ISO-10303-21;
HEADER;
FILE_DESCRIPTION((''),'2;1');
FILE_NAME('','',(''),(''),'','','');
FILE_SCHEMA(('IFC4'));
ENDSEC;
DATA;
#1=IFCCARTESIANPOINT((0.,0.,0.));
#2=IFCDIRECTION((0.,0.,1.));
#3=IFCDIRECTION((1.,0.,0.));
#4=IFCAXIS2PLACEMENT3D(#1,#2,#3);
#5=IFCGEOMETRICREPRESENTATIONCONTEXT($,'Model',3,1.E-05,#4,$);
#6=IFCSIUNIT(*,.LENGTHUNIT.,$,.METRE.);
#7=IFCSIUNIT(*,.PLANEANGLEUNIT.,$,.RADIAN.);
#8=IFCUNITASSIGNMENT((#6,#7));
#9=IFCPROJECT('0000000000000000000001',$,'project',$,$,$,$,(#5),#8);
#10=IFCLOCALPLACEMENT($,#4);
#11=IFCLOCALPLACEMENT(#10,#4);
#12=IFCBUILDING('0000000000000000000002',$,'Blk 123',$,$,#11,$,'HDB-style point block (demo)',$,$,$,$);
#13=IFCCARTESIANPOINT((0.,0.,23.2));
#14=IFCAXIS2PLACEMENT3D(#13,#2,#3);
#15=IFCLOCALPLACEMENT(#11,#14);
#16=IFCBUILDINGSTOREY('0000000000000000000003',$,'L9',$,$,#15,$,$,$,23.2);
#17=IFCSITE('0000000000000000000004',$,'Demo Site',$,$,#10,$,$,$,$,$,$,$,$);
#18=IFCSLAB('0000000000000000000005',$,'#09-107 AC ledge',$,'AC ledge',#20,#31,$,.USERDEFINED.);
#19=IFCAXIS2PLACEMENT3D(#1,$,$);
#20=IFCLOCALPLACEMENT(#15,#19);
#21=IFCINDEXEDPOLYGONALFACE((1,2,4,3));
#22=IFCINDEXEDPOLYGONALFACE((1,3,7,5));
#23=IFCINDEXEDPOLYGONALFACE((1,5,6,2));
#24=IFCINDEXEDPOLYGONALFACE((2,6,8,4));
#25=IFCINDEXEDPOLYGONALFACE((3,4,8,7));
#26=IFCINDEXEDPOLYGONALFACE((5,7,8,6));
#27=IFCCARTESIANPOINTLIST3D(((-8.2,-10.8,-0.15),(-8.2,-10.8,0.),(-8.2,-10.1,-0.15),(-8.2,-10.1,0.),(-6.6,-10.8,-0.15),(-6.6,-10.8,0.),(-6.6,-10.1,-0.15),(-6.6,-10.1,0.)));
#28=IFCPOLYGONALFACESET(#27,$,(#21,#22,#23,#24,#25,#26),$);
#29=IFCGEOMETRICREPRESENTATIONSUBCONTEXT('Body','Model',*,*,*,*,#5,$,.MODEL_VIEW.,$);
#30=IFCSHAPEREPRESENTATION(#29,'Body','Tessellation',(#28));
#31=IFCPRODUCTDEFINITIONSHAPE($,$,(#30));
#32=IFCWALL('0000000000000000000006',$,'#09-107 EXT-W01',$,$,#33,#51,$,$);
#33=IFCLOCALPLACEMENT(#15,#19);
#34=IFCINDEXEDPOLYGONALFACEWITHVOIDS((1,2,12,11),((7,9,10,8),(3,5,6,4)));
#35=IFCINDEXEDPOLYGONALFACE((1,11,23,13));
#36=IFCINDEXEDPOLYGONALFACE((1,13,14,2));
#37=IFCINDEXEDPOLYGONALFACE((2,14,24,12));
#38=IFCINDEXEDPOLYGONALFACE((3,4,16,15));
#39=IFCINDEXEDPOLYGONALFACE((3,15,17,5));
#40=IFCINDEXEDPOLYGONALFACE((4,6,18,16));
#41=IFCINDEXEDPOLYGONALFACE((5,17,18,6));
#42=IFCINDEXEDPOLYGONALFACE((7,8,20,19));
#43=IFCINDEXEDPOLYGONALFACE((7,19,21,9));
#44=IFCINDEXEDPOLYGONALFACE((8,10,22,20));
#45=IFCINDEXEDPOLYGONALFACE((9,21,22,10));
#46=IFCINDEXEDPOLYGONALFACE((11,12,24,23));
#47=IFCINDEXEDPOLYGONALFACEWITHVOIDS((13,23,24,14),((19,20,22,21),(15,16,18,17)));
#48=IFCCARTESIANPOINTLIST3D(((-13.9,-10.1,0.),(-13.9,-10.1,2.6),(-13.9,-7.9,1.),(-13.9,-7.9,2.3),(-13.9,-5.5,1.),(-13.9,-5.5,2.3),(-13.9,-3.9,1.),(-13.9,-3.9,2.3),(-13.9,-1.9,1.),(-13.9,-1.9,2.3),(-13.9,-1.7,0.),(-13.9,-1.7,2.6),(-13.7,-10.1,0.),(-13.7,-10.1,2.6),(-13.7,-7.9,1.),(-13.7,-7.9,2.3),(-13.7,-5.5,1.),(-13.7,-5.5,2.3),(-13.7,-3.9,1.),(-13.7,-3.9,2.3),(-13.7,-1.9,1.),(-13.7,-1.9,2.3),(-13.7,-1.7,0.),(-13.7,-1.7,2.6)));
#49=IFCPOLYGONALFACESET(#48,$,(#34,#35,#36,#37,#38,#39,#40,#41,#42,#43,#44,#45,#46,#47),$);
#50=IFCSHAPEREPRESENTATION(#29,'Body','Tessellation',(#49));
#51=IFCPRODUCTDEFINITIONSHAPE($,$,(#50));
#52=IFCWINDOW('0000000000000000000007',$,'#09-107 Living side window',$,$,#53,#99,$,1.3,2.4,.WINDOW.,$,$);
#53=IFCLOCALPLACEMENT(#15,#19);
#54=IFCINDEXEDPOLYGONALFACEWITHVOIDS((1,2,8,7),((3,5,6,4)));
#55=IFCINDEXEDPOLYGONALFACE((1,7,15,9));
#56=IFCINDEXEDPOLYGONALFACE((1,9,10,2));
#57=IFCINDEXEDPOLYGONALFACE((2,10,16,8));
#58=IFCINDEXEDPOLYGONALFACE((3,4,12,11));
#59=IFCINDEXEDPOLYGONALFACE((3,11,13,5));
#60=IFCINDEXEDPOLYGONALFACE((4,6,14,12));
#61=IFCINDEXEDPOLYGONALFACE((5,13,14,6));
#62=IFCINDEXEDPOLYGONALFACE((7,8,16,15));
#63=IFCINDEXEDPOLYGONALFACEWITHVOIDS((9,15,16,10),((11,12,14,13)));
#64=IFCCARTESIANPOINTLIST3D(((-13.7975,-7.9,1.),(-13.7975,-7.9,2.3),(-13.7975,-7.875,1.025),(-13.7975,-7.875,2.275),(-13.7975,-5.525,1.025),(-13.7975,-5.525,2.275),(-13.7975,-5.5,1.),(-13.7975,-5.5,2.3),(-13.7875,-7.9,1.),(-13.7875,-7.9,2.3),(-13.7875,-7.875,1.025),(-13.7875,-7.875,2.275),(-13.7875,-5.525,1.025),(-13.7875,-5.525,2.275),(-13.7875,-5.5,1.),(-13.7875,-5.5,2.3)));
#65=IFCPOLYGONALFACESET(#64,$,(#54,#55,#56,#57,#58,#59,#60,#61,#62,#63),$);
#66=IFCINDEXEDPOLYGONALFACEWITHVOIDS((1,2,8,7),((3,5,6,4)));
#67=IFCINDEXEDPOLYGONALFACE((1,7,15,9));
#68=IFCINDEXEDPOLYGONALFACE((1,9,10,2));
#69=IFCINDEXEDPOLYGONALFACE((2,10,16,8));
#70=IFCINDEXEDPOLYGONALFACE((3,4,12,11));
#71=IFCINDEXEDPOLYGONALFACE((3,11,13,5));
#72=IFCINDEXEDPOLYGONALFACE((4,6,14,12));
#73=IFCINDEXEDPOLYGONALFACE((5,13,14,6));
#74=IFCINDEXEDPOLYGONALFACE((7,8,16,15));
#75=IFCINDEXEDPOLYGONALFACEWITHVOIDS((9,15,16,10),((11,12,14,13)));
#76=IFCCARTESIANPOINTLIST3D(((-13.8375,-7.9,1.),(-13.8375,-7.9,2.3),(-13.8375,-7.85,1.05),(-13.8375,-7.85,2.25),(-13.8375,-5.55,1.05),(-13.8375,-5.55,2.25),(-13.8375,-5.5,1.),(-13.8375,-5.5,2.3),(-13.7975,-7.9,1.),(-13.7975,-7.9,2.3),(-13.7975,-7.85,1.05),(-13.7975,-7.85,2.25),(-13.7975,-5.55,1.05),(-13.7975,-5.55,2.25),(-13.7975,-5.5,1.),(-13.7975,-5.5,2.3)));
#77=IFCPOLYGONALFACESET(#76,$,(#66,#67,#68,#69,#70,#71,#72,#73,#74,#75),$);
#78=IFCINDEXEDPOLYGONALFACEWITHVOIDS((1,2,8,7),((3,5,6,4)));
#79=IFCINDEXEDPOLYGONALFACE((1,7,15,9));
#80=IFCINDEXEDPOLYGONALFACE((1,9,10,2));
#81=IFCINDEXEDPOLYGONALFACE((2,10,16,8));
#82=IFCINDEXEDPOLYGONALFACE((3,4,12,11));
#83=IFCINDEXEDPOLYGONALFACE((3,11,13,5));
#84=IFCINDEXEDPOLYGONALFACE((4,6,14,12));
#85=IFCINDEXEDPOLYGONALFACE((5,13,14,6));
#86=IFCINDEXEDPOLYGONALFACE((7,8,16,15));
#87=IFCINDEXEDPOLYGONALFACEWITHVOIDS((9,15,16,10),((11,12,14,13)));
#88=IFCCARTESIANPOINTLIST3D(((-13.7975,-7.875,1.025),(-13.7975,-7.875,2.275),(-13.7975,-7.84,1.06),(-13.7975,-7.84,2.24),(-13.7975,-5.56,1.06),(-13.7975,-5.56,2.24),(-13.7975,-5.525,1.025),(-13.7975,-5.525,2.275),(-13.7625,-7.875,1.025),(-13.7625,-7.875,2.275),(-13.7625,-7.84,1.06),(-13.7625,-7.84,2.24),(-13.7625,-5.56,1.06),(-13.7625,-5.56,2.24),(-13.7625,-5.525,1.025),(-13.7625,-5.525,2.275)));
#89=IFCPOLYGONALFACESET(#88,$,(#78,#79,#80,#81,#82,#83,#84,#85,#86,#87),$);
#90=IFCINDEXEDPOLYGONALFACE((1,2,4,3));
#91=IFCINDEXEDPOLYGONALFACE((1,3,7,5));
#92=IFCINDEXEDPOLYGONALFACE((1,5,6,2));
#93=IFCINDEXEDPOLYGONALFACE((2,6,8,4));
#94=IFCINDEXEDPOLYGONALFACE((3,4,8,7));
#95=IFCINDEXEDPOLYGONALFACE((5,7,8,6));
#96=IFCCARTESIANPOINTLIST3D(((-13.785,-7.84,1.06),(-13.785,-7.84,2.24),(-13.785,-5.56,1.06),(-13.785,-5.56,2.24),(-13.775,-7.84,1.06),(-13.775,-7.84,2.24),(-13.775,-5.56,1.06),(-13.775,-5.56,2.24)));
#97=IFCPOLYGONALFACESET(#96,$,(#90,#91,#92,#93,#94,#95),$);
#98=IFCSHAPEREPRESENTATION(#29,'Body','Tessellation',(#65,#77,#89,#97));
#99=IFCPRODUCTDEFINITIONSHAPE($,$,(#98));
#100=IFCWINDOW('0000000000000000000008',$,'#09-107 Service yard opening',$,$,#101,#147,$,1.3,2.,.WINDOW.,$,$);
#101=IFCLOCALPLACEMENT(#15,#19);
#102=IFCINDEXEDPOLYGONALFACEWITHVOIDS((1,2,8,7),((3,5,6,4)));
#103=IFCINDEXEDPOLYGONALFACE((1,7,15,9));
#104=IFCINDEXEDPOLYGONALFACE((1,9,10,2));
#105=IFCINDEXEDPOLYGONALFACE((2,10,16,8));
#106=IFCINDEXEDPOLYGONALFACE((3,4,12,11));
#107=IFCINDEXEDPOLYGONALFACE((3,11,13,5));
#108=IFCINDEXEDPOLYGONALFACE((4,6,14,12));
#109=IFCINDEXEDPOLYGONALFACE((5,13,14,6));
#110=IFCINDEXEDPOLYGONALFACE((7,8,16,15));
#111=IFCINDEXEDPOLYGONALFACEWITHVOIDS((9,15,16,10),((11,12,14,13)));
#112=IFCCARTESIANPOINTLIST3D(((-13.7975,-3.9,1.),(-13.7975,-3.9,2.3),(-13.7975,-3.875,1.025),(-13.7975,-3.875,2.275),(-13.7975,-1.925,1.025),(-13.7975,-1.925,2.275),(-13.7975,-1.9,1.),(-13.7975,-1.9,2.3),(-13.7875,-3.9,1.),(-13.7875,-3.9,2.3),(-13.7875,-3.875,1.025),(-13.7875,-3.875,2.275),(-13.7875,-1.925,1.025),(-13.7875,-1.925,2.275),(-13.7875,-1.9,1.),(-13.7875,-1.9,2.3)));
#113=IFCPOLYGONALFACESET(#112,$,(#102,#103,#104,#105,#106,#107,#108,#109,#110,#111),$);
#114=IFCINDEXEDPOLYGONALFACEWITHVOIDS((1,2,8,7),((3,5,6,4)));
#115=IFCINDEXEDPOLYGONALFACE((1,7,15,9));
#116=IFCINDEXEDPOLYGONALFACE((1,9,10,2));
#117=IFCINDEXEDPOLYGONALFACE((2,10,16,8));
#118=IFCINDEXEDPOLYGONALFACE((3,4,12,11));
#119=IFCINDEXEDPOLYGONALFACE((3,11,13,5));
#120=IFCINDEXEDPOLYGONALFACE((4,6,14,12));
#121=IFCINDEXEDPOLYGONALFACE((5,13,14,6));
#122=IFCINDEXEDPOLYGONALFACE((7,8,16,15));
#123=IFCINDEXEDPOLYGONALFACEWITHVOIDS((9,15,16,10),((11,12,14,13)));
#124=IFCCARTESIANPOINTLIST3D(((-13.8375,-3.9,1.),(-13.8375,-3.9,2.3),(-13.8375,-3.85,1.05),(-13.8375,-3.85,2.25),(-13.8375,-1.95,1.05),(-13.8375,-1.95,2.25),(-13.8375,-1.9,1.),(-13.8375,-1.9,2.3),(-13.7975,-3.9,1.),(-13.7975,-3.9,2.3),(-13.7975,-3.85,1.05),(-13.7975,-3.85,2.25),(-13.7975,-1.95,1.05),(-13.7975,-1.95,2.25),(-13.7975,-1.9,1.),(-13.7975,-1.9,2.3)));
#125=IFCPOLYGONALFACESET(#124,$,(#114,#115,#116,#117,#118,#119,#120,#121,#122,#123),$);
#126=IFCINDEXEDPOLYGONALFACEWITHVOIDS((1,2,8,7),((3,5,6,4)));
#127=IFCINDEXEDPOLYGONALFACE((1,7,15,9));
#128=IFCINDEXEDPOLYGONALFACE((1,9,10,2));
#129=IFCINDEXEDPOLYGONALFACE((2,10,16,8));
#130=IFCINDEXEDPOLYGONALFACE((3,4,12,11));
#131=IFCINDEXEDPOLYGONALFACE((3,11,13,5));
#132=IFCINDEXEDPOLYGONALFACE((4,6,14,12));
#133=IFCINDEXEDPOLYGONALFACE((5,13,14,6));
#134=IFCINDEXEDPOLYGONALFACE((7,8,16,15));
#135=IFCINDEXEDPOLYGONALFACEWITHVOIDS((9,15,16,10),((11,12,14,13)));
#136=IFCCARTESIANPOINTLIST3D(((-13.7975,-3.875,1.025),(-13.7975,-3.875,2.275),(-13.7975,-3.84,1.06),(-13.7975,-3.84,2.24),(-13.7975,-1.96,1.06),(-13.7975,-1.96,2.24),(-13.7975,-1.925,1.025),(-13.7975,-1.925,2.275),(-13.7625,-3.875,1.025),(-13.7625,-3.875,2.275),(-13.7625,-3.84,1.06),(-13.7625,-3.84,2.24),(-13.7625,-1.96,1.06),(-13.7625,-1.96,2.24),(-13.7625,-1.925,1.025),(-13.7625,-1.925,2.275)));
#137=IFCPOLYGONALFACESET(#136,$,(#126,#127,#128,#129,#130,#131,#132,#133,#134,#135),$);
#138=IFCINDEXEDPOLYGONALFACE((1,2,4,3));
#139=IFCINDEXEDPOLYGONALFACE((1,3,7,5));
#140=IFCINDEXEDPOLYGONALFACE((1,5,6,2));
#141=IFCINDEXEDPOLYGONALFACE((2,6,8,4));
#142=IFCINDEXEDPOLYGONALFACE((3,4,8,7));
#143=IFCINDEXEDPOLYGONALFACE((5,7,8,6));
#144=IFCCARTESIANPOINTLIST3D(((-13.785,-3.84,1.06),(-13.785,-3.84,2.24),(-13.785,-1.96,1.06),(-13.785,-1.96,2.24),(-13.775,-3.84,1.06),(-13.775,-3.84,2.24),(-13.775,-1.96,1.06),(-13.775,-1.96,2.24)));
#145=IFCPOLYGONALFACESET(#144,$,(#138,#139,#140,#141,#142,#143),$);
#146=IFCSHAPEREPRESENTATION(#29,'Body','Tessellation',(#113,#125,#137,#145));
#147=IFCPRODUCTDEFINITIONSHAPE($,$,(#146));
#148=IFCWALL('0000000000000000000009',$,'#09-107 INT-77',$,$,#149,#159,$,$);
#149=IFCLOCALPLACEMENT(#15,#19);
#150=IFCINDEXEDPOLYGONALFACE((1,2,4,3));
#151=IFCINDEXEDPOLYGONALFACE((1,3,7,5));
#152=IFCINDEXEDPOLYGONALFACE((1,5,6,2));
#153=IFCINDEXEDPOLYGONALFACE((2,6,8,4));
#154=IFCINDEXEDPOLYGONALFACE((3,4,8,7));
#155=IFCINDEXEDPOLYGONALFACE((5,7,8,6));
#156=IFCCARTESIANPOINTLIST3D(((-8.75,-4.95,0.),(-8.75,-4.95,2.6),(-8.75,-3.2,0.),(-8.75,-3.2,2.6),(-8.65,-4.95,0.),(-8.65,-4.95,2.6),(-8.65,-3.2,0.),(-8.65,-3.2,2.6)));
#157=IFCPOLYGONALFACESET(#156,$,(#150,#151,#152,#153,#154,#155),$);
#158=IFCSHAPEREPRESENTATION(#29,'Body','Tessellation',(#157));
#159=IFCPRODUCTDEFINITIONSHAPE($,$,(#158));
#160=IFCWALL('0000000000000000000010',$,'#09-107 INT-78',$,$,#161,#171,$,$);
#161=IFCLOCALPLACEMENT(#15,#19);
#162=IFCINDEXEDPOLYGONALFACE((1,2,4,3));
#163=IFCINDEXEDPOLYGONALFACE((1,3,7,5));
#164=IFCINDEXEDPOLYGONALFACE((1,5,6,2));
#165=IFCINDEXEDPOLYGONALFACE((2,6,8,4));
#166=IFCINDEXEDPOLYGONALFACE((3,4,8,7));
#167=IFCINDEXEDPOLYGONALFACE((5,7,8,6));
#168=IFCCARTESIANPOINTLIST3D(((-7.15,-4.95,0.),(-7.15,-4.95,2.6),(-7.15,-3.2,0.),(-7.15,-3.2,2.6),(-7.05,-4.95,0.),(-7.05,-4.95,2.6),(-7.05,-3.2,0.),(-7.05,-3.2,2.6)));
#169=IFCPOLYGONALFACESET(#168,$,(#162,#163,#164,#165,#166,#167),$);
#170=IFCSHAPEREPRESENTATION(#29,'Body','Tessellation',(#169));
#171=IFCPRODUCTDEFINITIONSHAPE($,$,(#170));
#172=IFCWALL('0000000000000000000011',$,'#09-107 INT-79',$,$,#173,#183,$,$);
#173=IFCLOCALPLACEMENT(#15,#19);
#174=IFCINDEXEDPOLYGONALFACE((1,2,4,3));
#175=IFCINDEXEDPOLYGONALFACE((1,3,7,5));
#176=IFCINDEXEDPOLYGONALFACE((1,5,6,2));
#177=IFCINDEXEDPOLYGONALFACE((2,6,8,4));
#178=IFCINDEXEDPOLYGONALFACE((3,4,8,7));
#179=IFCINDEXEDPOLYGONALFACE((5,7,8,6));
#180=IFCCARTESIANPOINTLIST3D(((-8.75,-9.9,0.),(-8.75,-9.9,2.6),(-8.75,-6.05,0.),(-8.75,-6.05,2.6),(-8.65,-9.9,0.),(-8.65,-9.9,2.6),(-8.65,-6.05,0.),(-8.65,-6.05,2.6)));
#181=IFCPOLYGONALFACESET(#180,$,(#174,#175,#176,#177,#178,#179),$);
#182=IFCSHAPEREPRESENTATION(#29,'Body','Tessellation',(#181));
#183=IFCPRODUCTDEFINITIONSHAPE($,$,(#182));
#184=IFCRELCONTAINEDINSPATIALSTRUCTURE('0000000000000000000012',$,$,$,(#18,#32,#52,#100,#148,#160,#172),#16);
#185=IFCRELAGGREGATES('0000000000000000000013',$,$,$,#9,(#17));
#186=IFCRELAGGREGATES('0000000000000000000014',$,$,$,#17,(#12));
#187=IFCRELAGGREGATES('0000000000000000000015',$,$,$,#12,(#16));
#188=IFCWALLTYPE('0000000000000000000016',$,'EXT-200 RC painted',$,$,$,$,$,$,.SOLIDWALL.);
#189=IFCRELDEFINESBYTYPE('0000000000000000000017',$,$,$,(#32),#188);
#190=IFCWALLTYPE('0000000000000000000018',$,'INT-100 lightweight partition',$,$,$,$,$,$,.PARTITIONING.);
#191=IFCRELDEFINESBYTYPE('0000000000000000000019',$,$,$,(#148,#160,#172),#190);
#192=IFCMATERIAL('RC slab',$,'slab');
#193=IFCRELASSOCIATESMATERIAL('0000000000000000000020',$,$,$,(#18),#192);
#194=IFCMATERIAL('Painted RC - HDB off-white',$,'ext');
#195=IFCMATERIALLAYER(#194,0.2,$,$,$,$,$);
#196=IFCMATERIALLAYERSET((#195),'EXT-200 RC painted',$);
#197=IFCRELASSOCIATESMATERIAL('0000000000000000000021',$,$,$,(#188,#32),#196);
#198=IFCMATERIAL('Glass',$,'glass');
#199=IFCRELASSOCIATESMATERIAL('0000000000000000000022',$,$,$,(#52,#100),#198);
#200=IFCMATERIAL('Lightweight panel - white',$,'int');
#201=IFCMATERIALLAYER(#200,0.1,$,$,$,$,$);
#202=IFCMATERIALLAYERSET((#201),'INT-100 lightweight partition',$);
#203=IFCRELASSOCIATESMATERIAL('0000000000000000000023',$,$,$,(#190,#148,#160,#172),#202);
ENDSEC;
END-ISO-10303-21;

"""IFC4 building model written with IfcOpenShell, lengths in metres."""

from ifc_helpers import new_model, si_unit, frame, origin, origin_with_axes, place, context, subcontext, project, spatial, polyline, line, indexed_curve, outline, extrude, material, layer, layer_set, layer_usage, type_object, element, fill, save


model = new_model("IFC4")

# Units and contexts
model_context = context("Model", 3, precision=1e-05, world=origin_with_axes())
body_context = subcontext(model_context, "Body", "Model", "MODEL_VIEW")
ifc_project = project(units=[si_unit("LENGTHUNIT", "METRE"), si_unit("PLANEANGLEUNIT", "RADIAN")], contexts=[model_context])

# Site, building, storey
site_placement = place(None, origin_with_axes())
site = spatial("IfcSite", under=ifc_project, at=site_placement, Name="Demo Site")
building_placement = place(site_placement, origin_with_axes())
building = spatial("IfcBuilding", under=site, at=building_placement, Name="Blk 123", LongName="HDB-style point block (demo)")
storey_placement = place(building_placement, frame((0.0, 0.0, 23.2), z_axis=(0.0, 0.0, 1.0), x_axis=(1.0, 0.0, 0.0)))
storey = spatial("IfcBuildingStorey", under=building, at=storey_placement, Name="L9", Elevation=23.2)

# Slab
ifc_material_1 = material(Name="RC slab", Category="slab")
slab_placement = place(storey_placement, frame((-7.4, -10.45, -0.15), z_axis=(0.0, 0.0, 1.0), x_axis=(1.0, 0.0, 0.0)))
element("IfcSlab", 1, at=slab_placement, inside=storey, material=ifc_material_1, Name="#09-107 AC ledge", ObjectType="AC ledge", PredefinedType="USERDEFINED", context=body_context, shape_type="SweptSolid", body=[
    extrude(outline(polyline([(-0.8, 0.35), (-0.8, -0.35), (0.8, -0.35), (0.8, 0.35), (-0.8, 0.35)])), origin(), (0.0, 0.0, 1.0), 0.15),
])

# Wall, openings, windows
ifc_material_2 = material(Name="Painted RC - HDB off-white", Category="ext")
ifc_layer_1 = layer(ifc_material_2, 0.2)
ifc_layer_set_1 = layer_set([ifc_layer_1], Name="EXT-200 RC painted")
ifc_layer_usage_1 = layer_usage(ifc_layer_set_1, "AXIS2", "POSITIVE", 0.0)
wall_type_1 = type_object("IfcWallType", Name="EXT-200 RC painted", PredefinedType="SOLIDWALL", material=ifc_layer_set_1)
wall_1_placement = place(storey_placement, frame((-13.9, -1.7, 0.0), z_axis=(0.0, 0.0, 1.0), x_axis=(0.0, -1.0, 0.0)))
wall_1 = element("IfcWall", 2, at=wall_1_placement, inside=storey, type_object=wall_type_1, material=ifc_layer_usage_1, Name="#09-107 EXT-W01", context=body_context, shape_type="SweptSolid", body=[
    extrude(outline(indexed_curve([(0.0, 0.0), (0.0, 0.2), (8.4, 0.2), (8.4, 0.0), (0.0, 0.0)], self_intersect=False)), origin_with_axes(), (0.0, 0.0, 1.0), 2.6),
])
opening_1_placement = place(wall_1_placement, frame((3.8, -0.1, 1.0), z_axis=(0.0, 0.0, 1.0), x_axis=(1.0, 0.0, 0.0)))
opening_1 = element("IfcOpeningElement", 3, at=opening_1_placement, cuts=wall_1, context=body_context, shape_type="SweptSolid", body=[
    extrude(outline(indexed_curve([(0.0, 0.0), (0.0, 0.4), (2.4, 0.4), (2.4, 0.0), (0.0, 0.0)], self_intersect=False)), origin_with_axes(), (0.0, 0.0, 1.0), 1.3),
])
opening_2_placement = place(wall_1_placement, frame((0.2, -0.1, 1.0), z_axis=(0.0, 0.0, 1.0), x_axis=(1.0, 0.0, 0.0)))
opening_2 = element("IfcOpeningElement", 4, at=opening_2_placement, cuts=wall_1, context=body_context, shape_type="SweptSolid", body=[
    extrude(outline(indexed_curve([(0.0, 0.0), (0.0, 0.4), (2.0, 0.4), (2.0, 0.0), (0.0, 0.0)], self_intersect=False)), origin_with_axes(), (0.0, 0.0, 1.0), 1.3),
])
ifc_material_3 = material(Name="Glass", Category="glass")
window_1_placement = place(opening_1_placement, frame((0.0, 0.1125, 0.0), z_axis=(0.0, 0.0, 1.0), x_axis=(1.0, 0.0, 0.0)))
window_1 = element("IfcWindow", 5, at=window_1_placement, inside=storey, material=ifc_material_3, Name="#09-107 Living side window", OverallHeight=1.3, OverallWidth=2.4, PredefinedType="WINDOW", context=body_context, shape_type="SweptSolid", body=[
    extrude(outline(indexed_curve([(0.0, 0.0), (2.4, 0.0), (2.4, 1.3), (0.0, 1.3)], segments=[line(1, 2, 3, 4, 1)]), holes=[indexed_curve([(0.025, 0.025), (2.375, 0.025), (2.375, 1.275), (0.025, 1.275)], segments=[line(1, 2, 3, 4, 1)])]), frame((0.0, 0.09, 0.0), z_axis=(0.0, -1.0, 0.0), x_axis=(1.0, 0.0, 0.0)), (0.0, 0.0, -1.0), 0.01),
    extrude(outline(indexed_curve([(0.0, 0.0), (2.4, 0.0), (2.4, 1.3), (0.0, 1.3)], segments=[line(1, 2, 3, 4, 1)]), holes=[indexed_curve([(0.05, 0.05), (2.35, 0.05), (2.35, 1.25), (0.05, 1.25)], segments=[line(1, 2, 3, 4, 1)])]), frame((0.0, 0.05, 0.0), z_axis=(0.0, -1.0, 0.0), x_axis=(1.0, 0.0, 0.0)), (0.0, 0.0, -1.0), 0.04),
    extrude(outline(indexed_curve([(0.0, 0.0), (2.35, 0.0), (2.35, 1.25), (0.0, 1.25)], segments=[line(1, 2, 3, 4, 1)]), holes=[indexed_curve([(0.035, 0.035), (2.315, 0.035), (2.315, 1.215), (0.035, 1.215)], segments=[line(1, 2, 3, 4, 1)])]), frame((0.025, 0.09, 0.025), z_axis=(0.0, -1.0, 0.0), x_axis=(1.0, 0.0, 0.0)), (0.0, 0.0, -1.0), 0.035),
    extrude(outline(indexed_curve([(0.035, 0.035), (2.315, 0.035), (2.315, 1.215), (0.035, 1.215)], segments=[line(1, 2, 3, 4, 1)])), frame((0.025, 0.1025, 0.025), z_axis=(0.0, -1.0, 0.0), x_axis=(1.0, 0.0, 0.0)), (0.0, 0.0, -1.0), 0.01),
])
fill(opening_1, window_1)
window_2_placement = place(opening_2_placement, frame((0.0, 0.1125, 0.0), z_axis=(0.0, 0.0, 1.0), x_axis=(1.0, 0.0, 0.0)))
window_2 = element("IfcWindow", 6, at=window_2_placement, inside=storey, material=ifc_material_3, Name="#09-107 Service yard opening", OverallHeight=1.3, OverallWidth=2.0, PredefinedType="WINDOW", context=body_context, shape_type="SweptSolid", body=[
    extrude(outline(indexed_curve([(0.0, 0.0), (2.0, 0.0), (2.0, 1.3), (0.0, 1.3)], segments=[line(1, 2, 3, 4, 1)]), holes=[indexed_curve([(0.025, 0.025), (1.975, 0.025), (1.975, 1.275), (0.025, 1.275)], segments=[line(1, 2, 3, 4, 1)])]), frame((0.0, 0.09, 0.0), z_axis=(0.0, -1.0, 0.0), x_axis=(1.0, 0.0, 0.0)), (0.0, 0.0, -1.0), 0.01),
    extrude(outline(indexed_curve([(0.0, 0.0), (2.0, 0.0), (2.0, 1.3), (0.0, 1.3)], segments=[line(1, 2, 3, 4, 1)]), holes=[indexed_curve([(0.05, 0.05), (1.95, 0.05), (1.95, 1.25), (0.05, 1.25)], segments=[line(1, 2, 3, 4, 1)])]), frame((0.0, 0.05, 0.0), z_axis=(0.0, -1.0, 0.0), x_axis=(1.0, 0.0, 0.0)), (0.0, 0.0, -1.0), 0.04),
    extrude(outline(indexed_curve([(0.0, 0.0), (1.95, 0.0), (1.95, 1.25), (0.0, 1.25)], segments=[line(1, 2, 3, 4, 1)]), holes=[indexed_curve([(0.035, 0.035), (1.915, 0.035), (1.915, 1.215), (0.035, 1.215)], segments=[line(1, 2, 3, 4, 1)])]), frame((0.025, 0.09, 0.025), z_axis=(0.0, -1.0, 0.0), x_axis=(1.0, 0.0, 0.0)), (0.0, 0.0, -1.0), 0.035),
    extrude(outline(indexed_curve([(0.035, 0.035), (1.915, 0.035), (1.915, 1.215), (0.035, 1.215)], segments=[line(1, 2, 3, 4, 1)])), frame((0.025, 0.1025, 0.025), z_axis=(0.0, -1.0, 0.0), x_axis=(1.0, 0.0, 0.0)), (0.0, 0.0, -1.0), 0.01),
])
fill(opening_2, window_2)

# Walls
ifc_material_4 = material(Name="Lightweight panel - white", Category="int")
ifc_layer_2 = layer(ifc_material_4, 0.1)
ifc_layer_set_2 = layer_set([ifc_layer_2], Name="INT-100 lightweight partition")
ifc_layer_usage_2 = layer_usage(ifc_layer_set_2, "AXIS2", "POSITIVE", -0.05)
wall_type_2 = type_object("IfcWallType", Name="INT-100 lightweight partition", PredefinedType="PARTITIONING", material=ifc_layer_set_2)
for number, where, z_axis, x_axis, name in (
    (7, (-8.7, -3.2, 0.0), (0.0, 0.0, 1.0), (0.0, -1.0, 0.0), "#09-107 INT-77"),
    (8, (-7.1, -3.2, 0.0), (0.0, 0.0, 1.0), (0.0, -1.0, 0.0), "#09-107 INT-78"),
):
    element("IfcWall", number, at=place(storey_placement, frame(where, z_axis=z_axis, x_axis=x_axis)), inside=storey, type_object=wall_type_2, material=ifc_layer_usage_2, Name=name, context=body_context, shape_type="SweptSolid", body=[
        extrude(outline(indexed_curve([(0.0, 0.0), (0.0, 0.1), (1.75, 0.1), (1.75, 0.0), (0.0, 0.0)], self_intersect=False)), frame((0.0, -0.05, 0.0), z_axis=(0.0, 0.0, 1.0), x_axis=(1.0, 0.0, 0.0)), (0.0, 0.0, 1.0), 2.6),
    ])
wall_2_placement = place(storey_placement, frame((-8.7, -6.05, 0.0), z_axis=(0.0, 0.0, 1.0), x_axis=(0.0, -1.0, 0.0)))
element("IfcWall", 9, at=wall_2_placement, inside=storey, type_object=wall_type_2, material=ifc_layer_usage_2, Name="#09-107 INT-79", context=body_context, shape_type="SweptSolid", body=[
    extrude(outline(indexed_curve([(0.0, 0.0), (0.0, 0.1), (3.85, 0.1), (3.85, 0.0), (0.0, 0.0)], self_intersect=False)), frame((0.0, -0.05, 0.0), z_axis=(0.0, 0.0, 1.0), x_axis=(1.0, 0.0, 0.0)), (0.0, 0.0, 1.0), 2.6),
])

save(model, "model.ifc")
